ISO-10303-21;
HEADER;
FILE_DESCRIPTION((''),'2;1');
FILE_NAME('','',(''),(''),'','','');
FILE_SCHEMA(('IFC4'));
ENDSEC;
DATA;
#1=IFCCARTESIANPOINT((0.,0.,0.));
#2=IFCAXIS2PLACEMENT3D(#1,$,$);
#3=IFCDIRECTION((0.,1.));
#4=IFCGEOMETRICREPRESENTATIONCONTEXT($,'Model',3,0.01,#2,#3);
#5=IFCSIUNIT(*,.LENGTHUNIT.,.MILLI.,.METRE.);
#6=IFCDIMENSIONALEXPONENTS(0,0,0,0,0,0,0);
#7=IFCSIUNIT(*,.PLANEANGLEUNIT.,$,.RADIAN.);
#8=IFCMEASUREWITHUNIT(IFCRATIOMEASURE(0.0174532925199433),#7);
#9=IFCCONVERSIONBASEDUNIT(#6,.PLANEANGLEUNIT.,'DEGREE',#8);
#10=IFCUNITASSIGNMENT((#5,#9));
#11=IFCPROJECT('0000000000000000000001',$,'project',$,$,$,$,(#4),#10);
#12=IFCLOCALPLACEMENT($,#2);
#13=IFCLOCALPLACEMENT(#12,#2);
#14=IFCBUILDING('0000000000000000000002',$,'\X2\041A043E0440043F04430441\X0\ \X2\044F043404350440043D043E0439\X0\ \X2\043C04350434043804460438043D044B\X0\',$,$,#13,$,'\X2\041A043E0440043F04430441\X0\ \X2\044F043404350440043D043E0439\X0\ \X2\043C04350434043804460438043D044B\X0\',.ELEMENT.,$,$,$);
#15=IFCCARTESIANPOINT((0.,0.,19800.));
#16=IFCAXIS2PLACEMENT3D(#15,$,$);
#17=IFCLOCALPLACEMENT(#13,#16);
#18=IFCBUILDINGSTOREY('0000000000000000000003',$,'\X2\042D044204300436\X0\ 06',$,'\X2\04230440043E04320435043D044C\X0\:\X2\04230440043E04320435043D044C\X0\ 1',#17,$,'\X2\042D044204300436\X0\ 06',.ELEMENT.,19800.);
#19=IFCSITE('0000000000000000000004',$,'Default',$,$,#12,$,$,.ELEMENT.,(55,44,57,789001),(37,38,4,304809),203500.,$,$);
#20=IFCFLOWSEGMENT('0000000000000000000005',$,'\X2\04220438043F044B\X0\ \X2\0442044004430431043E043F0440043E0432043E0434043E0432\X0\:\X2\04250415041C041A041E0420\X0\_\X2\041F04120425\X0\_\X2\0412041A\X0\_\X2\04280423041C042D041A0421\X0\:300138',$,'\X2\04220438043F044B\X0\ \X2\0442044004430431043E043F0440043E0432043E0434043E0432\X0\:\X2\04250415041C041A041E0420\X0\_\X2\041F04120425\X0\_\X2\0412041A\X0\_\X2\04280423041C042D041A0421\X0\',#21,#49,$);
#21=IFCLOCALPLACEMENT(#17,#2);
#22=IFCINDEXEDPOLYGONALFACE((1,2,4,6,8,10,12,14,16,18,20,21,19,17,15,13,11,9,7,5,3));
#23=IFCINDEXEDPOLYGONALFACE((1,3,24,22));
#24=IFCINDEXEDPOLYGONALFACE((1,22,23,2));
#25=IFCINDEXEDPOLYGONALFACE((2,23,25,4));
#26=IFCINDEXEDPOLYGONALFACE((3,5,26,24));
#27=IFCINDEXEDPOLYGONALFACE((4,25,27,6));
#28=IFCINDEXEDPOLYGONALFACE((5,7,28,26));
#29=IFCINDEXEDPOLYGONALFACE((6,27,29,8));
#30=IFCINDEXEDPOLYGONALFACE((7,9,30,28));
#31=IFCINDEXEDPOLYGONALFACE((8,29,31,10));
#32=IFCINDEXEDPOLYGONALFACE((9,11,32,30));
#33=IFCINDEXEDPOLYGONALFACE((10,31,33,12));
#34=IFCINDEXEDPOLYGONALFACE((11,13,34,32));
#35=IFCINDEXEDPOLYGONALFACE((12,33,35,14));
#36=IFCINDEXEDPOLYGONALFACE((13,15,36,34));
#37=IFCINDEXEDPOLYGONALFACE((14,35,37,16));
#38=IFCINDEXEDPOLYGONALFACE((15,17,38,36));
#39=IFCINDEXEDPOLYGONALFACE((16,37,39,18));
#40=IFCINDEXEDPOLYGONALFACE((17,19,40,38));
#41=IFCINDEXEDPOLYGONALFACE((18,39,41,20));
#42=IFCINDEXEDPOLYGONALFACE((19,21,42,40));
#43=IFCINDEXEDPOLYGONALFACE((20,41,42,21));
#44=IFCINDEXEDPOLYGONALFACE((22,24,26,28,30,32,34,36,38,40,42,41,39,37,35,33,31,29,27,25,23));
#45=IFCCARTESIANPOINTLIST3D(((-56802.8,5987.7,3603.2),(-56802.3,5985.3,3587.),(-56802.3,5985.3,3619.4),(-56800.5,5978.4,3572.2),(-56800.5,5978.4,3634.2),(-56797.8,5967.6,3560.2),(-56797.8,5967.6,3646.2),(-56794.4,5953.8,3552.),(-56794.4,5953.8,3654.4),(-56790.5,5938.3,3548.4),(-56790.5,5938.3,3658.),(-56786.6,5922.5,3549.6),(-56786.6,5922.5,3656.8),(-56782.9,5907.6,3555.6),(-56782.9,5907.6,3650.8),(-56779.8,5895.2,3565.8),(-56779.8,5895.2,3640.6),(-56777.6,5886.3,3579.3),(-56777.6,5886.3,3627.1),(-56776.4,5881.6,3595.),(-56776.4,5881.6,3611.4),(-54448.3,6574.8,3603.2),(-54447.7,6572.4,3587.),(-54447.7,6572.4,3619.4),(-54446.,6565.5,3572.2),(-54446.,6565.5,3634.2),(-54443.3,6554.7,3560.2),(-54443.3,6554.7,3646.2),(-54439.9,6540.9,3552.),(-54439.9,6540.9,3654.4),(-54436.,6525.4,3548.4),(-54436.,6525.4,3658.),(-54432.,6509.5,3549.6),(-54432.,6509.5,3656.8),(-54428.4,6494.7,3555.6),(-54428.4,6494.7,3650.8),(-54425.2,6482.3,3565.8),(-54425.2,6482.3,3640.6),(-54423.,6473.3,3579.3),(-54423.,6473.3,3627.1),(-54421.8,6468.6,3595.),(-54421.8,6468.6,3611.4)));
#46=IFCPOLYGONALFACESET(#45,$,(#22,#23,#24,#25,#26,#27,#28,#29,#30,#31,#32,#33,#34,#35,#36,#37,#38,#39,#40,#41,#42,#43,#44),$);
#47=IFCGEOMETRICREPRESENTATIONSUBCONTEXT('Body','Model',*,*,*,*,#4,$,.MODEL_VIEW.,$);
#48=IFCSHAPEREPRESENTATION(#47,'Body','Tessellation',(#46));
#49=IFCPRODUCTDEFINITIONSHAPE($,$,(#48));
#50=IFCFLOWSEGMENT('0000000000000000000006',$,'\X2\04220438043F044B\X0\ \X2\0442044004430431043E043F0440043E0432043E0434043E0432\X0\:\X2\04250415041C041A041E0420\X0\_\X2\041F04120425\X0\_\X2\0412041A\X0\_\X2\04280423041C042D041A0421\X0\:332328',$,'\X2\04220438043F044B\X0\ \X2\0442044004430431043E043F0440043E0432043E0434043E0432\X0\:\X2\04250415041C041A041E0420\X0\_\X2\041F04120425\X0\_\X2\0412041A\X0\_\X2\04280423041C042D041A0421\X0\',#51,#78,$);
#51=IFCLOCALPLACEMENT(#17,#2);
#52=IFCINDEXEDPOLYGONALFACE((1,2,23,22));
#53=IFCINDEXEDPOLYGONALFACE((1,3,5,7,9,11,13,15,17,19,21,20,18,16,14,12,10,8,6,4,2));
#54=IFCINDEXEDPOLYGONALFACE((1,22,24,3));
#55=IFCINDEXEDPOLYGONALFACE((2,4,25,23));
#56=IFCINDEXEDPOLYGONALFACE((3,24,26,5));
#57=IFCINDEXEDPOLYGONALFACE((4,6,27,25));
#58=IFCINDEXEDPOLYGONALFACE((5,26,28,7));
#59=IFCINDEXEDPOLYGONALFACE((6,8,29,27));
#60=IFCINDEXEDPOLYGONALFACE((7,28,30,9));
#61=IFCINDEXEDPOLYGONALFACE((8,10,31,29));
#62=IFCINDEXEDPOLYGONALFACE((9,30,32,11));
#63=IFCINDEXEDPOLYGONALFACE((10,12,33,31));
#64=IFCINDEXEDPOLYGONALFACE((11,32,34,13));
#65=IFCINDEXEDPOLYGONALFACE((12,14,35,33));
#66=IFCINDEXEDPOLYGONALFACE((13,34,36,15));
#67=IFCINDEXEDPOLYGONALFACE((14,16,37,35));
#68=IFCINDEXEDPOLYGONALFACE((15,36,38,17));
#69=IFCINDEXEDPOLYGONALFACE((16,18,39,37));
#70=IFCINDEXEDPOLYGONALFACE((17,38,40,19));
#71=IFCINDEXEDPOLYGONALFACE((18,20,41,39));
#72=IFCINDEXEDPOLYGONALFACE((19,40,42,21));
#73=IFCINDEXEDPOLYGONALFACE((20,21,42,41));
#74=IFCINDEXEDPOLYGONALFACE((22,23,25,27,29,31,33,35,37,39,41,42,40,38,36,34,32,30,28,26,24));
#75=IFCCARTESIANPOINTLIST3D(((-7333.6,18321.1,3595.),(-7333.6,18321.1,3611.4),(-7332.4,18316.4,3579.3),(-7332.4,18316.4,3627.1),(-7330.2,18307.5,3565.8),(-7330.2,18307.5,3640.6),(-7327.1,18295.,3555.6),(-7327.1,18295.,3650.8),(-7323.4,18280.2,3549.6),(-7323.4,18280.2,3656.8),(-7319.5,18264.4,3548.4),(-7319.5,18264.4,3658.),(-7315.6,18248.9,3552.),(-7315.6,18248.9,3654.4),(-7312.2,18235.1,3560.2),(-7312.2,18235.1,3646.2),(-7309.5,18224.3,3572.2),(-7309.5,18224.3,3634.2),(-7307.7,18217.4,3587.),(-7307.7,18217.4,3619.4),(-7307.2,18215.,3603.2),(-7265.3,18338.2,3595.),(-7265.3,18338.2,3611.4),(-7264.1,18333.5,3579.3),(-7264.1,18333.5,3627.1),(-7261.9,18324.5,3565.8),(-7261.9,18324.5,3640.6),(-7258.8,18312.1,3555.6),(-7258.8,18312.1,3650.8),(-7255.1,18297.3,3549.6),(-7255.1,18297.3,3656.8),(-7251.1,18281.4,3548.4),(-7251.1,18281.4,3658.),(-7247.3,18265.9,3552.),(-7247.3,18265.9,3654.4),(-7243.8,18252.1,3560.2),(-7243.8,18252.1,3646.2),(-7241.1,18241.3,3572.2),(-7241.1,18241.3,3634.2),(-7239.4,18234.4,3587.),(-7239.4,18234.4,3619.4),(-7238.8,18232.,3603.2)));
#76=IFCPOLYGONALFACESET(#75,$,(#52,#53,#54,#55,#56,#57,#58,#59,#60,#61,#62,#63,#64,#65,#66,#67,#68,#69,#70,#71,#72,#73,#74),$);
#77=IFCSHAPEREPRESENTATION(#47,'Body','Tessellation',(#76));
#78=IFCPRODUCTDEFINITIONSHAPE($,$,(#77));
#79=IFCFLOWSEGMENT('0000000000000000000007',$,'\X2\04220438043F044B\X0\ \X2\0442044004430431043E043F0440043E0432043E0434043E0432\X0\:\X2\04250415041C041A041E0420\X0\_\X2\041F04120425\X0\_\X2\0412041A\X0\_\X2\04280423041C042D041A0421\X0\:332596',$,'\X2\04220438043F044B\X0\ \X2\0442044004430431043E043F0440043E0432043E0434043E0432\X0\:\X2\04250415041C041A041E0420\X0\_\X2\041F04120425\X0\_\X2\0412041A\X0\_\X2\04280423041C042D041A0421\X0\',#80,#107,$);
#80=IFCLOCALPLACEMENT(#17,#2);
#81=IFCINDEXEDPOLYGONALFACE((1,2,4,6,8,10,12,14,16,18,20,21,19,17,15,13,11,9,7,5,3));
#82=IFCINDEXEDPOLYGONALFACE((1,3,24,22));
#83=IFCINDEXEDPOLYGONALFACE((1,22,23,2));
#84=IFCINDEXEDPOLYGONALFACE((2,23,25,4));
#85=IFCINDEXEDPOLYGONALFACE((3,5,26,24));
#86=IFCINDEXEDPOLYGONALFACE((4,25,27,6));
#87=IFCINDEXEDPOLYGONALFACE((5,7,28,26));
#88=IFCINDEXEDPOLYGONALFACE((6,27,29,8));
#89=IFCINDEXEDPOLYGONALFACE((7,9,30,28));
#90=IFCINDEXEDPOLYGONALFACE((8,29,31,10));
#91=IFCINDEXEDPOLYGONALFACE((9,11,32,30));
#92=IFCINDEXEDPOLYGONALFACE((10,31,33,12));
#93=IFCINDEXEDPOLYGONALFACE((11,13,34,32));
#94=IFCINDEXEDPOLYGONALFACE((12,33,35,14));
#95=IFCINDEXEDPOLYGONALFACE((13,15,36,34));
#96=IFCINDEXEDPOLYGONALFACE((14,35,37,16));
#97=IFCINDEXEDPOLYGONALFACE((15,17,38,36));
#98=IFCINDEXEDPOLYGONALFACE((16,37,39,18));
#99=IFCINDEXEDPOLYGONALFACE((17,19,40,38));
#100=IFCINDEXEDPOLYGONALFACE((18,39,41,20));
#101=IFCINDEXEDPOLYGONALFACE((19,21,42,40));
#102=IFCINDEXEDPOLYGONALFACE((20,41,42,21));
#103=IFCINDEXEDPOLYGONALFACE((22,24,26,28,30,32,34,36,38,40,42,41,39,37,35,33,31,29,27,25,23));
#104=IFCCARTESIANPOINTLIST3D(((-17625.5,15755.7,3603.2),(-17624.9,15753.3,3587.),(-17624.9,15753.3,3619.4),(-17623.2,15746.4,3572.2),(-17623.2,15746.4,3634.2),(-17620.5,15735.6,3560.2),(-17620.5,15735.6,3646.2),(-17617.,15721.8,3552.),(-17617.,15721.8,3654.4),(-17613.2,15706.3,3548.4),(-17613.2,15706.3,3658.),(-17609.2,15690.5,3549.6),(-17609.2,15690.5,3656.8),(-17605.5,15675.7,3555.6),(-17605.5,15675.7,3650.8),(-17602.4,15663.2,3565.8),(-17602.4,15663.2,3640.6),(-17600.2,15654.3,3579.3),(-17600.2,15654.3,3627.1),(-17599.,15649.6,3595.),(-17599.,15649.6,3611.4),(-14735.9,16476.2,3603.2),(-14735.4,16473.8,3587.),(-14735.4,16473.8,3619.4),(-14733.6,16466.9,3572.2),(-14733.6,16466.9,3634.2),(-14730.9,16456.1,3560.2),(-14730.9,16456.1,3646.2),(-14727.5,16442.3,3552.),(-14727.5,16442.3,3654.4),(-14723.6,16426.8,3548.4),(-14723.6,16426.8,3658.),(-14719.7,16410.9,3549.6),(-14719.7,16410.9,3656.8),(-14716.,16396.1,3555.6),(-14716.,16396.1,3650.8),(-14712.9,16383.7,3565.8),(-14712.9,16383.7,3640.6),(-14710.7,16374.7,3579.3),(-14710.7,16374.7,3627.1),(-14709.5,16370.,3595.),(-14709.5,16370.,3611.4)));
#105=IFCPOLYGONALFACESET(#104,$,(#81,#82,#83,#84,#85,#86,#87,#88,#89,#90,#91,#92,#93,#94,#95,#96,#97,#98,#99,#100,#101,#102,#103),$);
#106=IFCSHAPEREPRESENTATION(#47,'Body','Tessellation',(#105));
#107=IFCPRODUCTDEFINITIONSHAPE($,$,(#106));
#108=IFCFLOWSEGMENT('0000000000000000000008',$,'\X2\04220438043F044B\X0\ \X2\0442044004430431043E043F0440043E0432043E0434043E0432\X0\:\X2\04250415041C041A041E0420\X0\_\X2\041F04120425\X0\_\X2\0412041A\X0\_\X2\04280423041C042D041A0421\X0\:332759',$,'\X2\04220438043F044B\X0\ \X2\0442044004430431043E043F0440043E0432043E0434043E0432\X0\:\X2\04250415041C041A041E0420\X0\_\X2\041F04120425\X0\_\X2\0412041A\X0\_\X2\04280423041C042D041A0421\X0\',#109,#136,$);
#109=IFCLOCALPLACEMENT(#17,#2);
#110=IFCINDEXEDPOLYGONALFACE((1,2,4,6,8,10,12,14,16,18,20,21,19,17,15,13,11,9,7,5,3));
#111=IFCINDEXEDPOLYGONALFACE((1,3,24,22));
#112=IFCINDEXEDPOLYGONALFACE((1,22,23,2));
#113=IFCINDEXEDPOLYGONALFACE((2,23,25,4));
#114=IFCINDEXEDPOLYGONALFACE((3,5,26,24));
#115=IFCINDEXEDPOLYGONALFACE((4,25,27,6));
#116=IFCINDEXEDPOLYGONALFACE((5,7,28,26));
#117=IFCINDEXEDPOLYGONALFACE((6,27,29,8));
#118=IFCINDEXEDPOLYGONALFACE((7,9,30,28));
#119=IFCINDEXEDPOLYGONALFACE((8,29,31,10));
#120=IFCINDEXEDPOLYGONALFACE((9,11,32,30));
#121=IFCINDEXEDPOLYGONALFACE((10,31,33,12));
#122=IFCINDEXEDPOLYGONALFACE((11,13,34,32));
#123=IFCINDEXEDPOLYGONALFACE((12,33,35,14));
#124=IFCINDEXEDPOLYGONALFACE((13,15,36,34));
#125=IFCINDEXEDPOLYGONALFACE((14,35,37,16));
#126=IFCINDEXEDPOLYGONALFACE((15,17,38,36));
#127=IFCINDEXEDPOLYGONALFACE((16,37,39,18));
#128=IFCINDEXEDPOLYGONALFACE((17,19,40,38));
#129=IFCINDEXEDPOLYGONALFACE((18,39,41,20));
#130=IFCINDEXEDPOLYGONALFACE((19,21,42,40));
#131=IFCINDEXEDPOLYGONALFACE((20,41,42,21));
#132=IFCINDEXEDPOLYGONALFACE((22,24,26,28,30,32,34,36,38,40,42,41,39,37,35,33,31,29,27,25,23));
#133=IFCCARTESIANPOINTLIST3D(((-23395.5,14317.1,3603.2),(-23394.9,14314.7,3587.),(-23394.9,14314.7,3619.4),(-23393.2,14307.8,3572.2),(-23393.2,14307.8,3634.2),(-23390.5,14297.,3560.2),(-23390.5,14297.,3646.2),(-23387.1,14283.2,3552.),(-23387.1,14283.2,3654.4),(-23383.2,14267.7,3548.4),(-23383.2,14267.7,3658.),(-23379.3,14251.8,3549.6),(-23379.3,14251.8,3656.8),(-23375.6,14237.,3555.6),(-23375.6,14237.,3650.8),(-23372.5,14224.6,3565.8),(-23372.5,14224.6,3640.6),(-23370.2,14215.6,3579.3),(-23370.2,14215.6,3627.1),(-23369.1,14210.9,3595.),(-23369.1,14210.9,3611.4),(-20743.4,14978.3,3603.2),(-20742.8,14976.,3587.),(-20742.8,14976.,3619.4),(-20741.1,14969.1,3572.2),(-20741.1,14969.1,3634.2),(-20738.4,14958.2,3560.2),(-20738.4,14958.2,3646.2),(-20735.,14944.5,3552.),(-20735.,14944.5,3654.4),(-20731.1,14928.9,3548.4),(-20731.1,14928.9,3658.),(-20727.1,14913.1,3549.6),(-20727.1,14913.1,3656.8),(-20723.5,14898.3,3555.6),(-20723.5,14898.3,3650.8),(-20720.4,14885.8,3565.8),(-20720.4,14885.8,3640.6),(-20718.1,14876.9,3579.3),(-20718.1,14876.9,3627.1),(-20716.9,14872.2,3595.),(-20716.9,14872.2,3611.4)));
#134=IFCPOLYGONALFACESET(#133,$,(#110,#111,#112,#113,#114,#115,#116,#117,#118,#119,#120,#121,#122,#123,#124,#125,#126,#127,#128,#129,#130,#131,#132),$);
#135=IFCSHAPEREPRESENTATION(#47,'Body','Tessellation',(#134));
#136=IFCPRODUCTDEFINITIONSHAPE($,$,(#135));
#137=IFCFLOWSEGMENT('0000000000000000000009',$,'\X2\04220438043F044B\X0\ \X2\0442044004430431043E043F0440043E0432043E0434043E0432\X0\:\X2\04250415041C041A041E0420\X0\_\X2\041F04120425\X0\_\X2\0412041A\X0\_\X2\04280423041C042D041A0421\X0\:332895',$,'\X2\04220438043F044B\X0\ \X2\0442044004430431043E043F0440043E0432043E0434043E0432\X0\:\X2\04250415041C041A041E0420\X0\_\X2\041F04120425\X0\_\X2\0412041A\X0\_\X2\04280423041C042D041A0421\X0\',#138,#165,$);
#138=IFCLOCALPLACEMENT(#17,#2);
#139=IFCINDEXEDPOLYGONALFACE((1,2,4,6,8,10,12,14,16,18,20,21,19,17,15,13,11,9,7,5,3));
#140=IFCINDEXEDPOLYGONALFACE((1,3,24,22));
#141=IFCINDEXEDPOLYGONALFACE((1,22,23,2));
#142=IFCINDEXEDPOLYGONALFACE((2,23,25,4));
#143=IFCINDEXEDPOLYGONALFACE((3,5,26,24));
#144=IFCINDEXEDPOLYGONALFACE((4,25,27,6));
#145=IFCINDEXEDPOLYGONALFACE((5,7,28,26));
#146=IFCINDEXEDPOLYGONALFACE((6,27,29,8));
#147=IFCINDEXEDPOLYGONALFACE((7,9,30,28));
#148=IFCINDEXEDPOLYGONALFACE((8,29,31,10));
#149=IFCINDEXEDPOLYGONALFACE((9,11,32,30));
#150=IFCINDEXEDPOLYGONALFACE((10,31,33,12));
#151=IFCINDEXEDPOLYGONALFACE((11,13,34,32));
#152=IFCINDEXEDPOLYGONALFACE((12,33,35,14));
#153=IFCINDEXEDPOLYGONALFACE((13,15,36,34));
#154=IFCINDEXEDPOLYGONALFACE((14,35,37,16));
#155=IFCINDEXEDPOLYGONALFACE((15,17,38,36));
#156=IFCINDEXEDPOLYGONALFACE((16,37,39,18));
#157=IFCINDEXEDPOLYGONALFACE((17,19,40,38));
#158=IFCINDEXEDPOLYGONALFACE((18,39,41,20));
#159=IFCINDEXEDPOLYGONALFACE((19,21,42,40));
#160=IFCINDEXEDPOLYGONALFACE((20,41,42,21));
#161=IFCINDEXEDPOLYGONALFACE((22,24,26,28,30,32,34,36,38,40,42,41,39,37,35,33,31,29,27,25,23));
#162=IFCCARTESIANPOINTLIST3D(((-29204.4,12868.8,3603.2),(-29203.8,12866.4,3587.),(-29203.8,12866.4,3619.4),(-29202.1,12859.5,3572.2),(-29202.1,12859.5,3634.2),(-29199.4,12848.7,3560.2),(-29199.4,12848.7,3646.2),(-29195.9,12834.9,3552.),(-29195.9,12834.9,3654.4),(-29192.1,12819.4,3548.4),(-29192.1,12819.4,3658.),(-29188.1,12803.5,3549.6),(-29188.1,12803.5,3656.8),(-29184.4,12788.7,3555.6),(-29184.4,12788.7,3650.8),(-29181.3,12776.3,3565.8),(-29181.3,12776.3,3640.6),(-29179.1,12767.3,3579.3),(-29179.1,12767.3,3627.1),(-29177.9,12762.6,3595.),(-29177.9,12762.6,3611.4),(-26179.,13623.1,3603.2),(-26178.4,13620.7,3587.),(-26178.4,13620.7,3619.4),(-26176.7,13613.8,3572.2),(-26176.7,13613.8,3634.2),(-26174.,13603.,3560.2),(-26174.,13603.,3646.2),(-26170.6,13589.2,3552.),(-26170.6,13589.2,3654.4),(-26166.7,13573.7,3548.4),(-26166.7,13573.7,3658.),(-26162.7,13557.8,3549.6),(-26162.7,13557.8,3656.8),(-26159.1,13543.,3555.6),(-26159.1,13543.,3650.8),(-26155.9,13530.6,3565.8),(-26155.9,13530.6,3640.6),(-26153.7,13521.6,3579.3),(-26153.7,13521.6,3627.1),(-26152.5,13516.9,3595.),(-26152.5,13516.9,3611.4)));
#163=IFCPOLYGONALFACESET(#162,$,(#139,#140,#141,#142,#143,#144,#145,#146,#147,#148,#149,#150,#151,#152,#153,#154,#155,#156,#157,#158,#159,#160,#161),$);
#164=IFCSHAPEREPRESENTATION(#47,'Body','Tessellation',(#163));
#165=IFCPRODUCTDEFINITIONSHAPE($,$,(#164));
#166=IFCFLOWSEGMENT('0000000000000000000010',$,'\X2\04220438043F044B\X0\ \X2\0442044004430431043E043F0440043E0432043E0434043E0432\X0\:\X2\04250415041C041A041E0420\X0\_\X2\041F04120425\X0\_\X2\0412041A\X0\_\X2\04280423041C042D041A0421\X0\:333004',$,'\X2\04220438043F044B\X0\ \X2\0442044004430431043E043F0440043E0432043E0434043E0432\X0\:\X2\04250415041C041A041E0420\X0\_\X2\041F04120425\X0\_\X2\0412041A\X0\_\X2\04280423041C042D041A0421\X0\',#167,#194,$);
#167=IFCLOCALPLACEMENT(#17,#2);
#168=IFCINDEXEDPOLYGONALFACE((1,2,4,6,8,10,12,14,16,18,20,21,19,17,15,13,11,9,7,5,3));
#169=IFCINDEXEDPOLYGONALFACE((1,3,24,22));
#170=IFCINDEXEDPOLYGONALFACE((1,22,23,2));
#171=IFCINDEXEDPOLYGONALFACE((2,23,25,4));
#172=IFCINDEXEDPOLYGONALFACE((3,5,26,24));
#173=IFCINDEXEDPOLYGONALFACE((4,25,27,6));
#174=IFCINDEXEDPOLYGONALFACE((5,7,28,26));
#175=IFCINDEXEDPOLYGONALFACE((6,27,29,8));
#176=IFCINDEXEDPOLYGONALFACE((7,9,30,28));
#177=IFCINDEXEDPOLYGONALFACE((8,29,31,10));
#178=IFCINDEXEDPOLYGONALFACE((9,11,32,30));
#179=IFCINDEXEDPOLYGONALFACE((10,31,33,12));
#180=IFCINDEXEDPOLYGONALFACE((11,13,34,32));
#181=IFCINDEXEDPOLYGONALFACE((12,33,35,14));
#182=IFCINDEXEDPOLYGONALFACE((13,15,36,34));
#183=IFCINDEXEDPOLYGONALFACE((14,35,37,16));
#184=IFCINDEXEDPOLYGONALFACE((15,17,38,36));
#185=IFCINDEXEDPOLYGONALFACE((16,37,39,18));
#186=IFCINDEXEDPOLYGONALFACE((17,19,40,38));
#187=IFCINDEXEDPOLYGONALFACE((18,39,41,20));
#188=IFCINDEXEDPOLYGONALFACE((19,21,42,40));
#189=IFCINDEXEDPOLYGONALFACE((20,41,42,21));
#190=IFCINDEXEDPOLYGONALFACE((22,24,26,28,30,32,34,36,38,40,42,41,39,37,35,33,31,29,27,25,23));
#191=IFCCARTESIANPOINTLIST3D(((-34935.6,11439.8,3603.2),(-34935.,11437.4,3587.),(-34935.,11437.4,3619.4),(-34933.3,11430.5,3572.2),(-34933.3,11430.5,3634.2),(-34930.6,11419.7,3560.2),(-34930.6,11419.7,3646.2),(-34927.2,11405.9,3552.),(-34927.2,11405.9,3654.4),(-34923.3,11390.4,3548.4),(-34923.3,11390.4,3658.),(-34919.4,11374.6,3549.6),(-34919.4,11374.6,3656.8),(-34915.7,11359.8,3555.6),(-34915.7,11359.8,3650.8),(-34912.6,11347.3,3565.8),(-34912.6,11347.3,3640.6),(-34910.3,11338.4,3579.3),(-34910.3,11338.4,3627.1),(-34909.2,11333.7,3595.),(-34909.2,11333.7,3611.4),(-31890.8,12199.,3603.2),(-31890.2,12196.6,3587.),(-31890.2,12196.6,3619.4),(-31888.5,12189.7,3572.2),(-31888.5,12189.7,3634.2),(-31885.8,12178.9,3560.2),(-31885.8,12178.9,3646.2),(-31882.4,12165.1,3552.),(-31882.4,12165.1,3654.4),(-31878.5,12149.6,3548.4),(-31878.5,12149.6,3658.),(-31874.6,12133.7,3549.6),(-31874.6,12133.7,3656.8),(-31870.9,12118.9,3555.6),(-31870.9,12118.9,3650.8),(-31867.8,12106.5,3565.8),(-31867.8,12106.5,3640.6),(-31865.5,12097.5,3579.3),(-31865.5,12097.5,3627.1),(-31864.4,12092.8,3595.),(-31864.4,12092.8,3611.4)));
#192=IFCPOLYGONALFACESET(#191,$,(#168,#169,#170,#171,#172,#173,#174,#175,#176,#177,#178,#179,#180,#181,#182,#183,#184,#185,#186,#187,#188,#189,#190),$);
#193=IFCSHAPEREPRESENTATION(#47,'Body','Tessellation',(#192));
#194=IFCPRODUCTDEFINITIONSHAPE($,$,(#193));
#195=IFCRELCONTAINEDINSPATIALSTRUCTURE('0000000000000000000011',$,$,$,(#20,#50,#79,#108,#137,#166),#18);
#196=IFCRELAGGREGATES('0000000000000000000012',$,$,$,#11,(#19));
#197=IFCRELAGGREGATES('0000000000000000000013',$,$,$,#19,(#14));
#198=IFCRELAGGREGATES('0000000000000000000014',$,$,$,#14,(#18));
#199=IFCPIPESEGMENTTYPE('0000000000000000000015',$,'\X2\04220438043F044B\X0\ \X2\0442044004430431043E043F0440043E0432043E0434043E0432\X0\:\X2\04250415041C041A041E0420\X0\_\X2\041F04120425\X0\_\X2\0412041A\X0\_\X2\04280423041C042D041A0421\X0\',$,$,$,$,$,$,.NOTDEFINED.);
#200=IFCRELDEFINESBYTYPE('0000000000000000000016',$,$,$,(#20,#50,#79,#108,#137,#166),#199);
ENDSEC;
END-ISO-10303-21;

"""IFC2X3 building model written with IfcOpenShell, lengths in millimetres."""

from ifc_helpers import new_model, entity, si_unit, converted_unit, direction, frame, origin, origin_2d_with_axis, place, context, subcontext, project, spatial, circle, extrude, type_object, element, save


model = new_model("IFC2X3")

# Units and contexts
model_context = context("Model", 3, precision=0.01, world=origin(), true_north=direction((0.0, 1.0)))
body_context = subcontext(model_context, "Body", "Model", "MODEL_VIEW")
ifc_project = project(units=[si_unit("LENGTHUNIT", "METRE", prefix="MILLI"), converted_unit("PLANEANGLEUNIT", "DEGREE", entity("IfcRatioMeasure", 0.0174532925199433), si_unit("PLANEANGLEUNIT", "RADIAN"), dimensions=[0, 0, 0, 0, 0, 0, 0])], contexts=[model_context])

# Site, building, storey
site_placement = place(None, frame((0.0, 0.0, 0.0)))
site = spatial("IfcSite", under=ifc_project, at=site_placement, Name="Default", CompositionType="ELEMENT", RefLatitude=(55, 44, 57, 789001), RefLongitude=(37, 38, 4, 304809), RefElevation=203500.0)
building_placement = place(site_placement, origin())
building = spatial("IfcBuilding", under=site, at=building_placement, Name="Корпус ядерной медицины", LongName="Корпус ядерной медицины", CompositionType="ELEMENT")
storey_placement = place(building_placement, frame((0.0, 0.0, 19800.0)))
storey = spatial("IfcBuildingStorey", under=building, at=storey_placement, Name="Этаж 06", ObjectType="Уровень:Уровень 1", LongName="Этаж 06", CompositionType="ELEMENT", Elevation=19800.0)

# Flow segments
pipe_segment_type = type_object("IfcPipeSegmentType", Name="Типы трубопроводов:ХЕМКОР_ПВХ_ВК_ШУМЭКС", PredefinedType="NOTDEFINED")
flow_segment_1_placement = place(storey_placement, frame((-56804.4, 5879.4, 3546.6)))
element("IfcFlowSegment", 1, at=flow_segment_1_placement, inside=storey, type_object=pipe_segment_type, Name="Типы трубопроводов:ХЕМКОР_ПВХ_ВК_ШУМЭКС:300138", ObjectType="Типы трубопроводов:ХЕМКОР_ПВХ_ВК_ШУМЭКС", context=body_context, shape_type="SweptSolid", body=[
    extrude(circle(Radius=55.0, at=origin_2d_with_axis()), frame((14.9, 55.0, 56.6), z_axis=(0.970296, 0.241922, 0.0), x_axis=(-0.241922, 0.970296, 0.0)), (0.0, 0.0, 1.0), 2426.6),
])
flow_segment_2_placement = place(storey_placement, frame((-7335.4, 18213.4, 3546.6)))
element("IfcFlowSegment", 2, at=flow_segment_2_placement, inside=storey, type_object=pipe_segment_type, Name="Типы трубопроводов:ХЕМКОР_ПВХ_ВК_ШУМЭКС:332328", ObjectType="Типы трубопроводов:ХЕМКОР_ПВХ_ВК_ШУМЭКС", context=body_context, shape_type="SweptSolid", body=[
    extrude(circle(Radius=55.0, at=origin_2d_with_axis()), frame((14.9, 55.0, 56.6), z_axis=(0.970296, 0.241922, 0.0), x_axis=(0.241922, -0.970296, 0.0)), (0.0, 0.0, 1.0), 70.4),
])
flow_segment_3_placement = place(storey_placement, frame((-17627.1, 15647.4, 3546.6)))
element("IfcFlowSegment", 3, at=flow_segment_3_placement, inside=storey, type_object=pipe_segment_type, Name="Типы трубопроводов:ХЕМКОР_ПВХ_ВК_ШУМЭКС:332596", ObjectType="Типы трубопроводов:ХЕМКОР_ПВХ_ВК_ШУМЭКС", context=body_context, shape_type="SweptSolid", body=[
    extrude(circle(Radius=55.0, at=origin_2d_with_axis()), frame((14.9, 55.0, 56.6), z_axis=(0.970296, 0.241922, 0.0), x_axis=(-0.241922, 0.970296, 0.0)), (0.0, 0.0, 1.0), 2978.0),
])
flow_segment_4_placement = place(storey_placement, frame((-23397.1, 14208.8, 3546.6)))
element("IfcFlowSegment", 4, at=flow_segment_4_placement, inside=storey, type_object=pipe_segment_type, Name="Типы трубопроводов:ХЕМКОР_ПВХ_ВК_ШУМЭКС:332759", ObjectType="Типы трубопроводов:ХЕМКОР_ПВХ_ВК_ШУМЭКС", context=body_context, shape_type="SweptSolid", body=[
    extrude(circle(Radius=55.0, at=origin_2d_with_axis()), frame((14.9, 55.0, 56.6), z_axis=(0.970296, 0.241922, 0.0), x_axis=(-0.241922, 0.970296, 0.0)), (0.0, 0.0, 1.0), 2733.3),
])
flow_segment_5_placement = place(storey_placement, frame((-29206.0, 12760.4, 3546.6)))
element("IfcFlowSegment", 5, at=flow_segment_5_placement, inside=storey, type_object=pipe_segment_type, Name="Типы трубопроводов:ХЕМКОР_ПВХ_ВК_ШУМЭКС:332895", ObjectType="Типы трубопроводов:ХЕМКОР_ПВХ_ВК_ШУМЭКС", context=body_context, shape_type="SweptSolid", body=[
    extrude(circle(Radius=55.0, at=origin_2d_with_axis()), frame((14.9, 55.0, 56.6), z_axis=(0.970296, 0.241922, 0.0), x_axis=(-0.241922, 0.970296, 0.0)), (0.0, 0.0, 1.0), 3118.0),
])
flow_segment_6_placement = place(storey_placement, frame((-34937.2, 11331.5, 3546.6)))
element("IfcFlowSegment", 6, at=flow_segment_6_placement, inside=storey, type_object=pipe_segment_type, Name="Типы трубопроводов:ХЕМКОР_ПВХ_ВК_ШУМЭКС:333004", ObjectType="Типы трубопроводов:ХЕМКОР_ПВХ_ВК_ШУМЭКС", context=body_context, shape_type="SweptSolid", body=[
    extrude(circle(Radius=55.0, at=origin_2d_with_axis()), frame((14.9, 55.0, 56.6), z_axis=(0.970296, 0.241922, 0.0), x_axis=(-0.241922, 0.970296, 0.0)), (0.0, 0.0, 1.0), 3138.0),
])

save(model, "model.ifc")
